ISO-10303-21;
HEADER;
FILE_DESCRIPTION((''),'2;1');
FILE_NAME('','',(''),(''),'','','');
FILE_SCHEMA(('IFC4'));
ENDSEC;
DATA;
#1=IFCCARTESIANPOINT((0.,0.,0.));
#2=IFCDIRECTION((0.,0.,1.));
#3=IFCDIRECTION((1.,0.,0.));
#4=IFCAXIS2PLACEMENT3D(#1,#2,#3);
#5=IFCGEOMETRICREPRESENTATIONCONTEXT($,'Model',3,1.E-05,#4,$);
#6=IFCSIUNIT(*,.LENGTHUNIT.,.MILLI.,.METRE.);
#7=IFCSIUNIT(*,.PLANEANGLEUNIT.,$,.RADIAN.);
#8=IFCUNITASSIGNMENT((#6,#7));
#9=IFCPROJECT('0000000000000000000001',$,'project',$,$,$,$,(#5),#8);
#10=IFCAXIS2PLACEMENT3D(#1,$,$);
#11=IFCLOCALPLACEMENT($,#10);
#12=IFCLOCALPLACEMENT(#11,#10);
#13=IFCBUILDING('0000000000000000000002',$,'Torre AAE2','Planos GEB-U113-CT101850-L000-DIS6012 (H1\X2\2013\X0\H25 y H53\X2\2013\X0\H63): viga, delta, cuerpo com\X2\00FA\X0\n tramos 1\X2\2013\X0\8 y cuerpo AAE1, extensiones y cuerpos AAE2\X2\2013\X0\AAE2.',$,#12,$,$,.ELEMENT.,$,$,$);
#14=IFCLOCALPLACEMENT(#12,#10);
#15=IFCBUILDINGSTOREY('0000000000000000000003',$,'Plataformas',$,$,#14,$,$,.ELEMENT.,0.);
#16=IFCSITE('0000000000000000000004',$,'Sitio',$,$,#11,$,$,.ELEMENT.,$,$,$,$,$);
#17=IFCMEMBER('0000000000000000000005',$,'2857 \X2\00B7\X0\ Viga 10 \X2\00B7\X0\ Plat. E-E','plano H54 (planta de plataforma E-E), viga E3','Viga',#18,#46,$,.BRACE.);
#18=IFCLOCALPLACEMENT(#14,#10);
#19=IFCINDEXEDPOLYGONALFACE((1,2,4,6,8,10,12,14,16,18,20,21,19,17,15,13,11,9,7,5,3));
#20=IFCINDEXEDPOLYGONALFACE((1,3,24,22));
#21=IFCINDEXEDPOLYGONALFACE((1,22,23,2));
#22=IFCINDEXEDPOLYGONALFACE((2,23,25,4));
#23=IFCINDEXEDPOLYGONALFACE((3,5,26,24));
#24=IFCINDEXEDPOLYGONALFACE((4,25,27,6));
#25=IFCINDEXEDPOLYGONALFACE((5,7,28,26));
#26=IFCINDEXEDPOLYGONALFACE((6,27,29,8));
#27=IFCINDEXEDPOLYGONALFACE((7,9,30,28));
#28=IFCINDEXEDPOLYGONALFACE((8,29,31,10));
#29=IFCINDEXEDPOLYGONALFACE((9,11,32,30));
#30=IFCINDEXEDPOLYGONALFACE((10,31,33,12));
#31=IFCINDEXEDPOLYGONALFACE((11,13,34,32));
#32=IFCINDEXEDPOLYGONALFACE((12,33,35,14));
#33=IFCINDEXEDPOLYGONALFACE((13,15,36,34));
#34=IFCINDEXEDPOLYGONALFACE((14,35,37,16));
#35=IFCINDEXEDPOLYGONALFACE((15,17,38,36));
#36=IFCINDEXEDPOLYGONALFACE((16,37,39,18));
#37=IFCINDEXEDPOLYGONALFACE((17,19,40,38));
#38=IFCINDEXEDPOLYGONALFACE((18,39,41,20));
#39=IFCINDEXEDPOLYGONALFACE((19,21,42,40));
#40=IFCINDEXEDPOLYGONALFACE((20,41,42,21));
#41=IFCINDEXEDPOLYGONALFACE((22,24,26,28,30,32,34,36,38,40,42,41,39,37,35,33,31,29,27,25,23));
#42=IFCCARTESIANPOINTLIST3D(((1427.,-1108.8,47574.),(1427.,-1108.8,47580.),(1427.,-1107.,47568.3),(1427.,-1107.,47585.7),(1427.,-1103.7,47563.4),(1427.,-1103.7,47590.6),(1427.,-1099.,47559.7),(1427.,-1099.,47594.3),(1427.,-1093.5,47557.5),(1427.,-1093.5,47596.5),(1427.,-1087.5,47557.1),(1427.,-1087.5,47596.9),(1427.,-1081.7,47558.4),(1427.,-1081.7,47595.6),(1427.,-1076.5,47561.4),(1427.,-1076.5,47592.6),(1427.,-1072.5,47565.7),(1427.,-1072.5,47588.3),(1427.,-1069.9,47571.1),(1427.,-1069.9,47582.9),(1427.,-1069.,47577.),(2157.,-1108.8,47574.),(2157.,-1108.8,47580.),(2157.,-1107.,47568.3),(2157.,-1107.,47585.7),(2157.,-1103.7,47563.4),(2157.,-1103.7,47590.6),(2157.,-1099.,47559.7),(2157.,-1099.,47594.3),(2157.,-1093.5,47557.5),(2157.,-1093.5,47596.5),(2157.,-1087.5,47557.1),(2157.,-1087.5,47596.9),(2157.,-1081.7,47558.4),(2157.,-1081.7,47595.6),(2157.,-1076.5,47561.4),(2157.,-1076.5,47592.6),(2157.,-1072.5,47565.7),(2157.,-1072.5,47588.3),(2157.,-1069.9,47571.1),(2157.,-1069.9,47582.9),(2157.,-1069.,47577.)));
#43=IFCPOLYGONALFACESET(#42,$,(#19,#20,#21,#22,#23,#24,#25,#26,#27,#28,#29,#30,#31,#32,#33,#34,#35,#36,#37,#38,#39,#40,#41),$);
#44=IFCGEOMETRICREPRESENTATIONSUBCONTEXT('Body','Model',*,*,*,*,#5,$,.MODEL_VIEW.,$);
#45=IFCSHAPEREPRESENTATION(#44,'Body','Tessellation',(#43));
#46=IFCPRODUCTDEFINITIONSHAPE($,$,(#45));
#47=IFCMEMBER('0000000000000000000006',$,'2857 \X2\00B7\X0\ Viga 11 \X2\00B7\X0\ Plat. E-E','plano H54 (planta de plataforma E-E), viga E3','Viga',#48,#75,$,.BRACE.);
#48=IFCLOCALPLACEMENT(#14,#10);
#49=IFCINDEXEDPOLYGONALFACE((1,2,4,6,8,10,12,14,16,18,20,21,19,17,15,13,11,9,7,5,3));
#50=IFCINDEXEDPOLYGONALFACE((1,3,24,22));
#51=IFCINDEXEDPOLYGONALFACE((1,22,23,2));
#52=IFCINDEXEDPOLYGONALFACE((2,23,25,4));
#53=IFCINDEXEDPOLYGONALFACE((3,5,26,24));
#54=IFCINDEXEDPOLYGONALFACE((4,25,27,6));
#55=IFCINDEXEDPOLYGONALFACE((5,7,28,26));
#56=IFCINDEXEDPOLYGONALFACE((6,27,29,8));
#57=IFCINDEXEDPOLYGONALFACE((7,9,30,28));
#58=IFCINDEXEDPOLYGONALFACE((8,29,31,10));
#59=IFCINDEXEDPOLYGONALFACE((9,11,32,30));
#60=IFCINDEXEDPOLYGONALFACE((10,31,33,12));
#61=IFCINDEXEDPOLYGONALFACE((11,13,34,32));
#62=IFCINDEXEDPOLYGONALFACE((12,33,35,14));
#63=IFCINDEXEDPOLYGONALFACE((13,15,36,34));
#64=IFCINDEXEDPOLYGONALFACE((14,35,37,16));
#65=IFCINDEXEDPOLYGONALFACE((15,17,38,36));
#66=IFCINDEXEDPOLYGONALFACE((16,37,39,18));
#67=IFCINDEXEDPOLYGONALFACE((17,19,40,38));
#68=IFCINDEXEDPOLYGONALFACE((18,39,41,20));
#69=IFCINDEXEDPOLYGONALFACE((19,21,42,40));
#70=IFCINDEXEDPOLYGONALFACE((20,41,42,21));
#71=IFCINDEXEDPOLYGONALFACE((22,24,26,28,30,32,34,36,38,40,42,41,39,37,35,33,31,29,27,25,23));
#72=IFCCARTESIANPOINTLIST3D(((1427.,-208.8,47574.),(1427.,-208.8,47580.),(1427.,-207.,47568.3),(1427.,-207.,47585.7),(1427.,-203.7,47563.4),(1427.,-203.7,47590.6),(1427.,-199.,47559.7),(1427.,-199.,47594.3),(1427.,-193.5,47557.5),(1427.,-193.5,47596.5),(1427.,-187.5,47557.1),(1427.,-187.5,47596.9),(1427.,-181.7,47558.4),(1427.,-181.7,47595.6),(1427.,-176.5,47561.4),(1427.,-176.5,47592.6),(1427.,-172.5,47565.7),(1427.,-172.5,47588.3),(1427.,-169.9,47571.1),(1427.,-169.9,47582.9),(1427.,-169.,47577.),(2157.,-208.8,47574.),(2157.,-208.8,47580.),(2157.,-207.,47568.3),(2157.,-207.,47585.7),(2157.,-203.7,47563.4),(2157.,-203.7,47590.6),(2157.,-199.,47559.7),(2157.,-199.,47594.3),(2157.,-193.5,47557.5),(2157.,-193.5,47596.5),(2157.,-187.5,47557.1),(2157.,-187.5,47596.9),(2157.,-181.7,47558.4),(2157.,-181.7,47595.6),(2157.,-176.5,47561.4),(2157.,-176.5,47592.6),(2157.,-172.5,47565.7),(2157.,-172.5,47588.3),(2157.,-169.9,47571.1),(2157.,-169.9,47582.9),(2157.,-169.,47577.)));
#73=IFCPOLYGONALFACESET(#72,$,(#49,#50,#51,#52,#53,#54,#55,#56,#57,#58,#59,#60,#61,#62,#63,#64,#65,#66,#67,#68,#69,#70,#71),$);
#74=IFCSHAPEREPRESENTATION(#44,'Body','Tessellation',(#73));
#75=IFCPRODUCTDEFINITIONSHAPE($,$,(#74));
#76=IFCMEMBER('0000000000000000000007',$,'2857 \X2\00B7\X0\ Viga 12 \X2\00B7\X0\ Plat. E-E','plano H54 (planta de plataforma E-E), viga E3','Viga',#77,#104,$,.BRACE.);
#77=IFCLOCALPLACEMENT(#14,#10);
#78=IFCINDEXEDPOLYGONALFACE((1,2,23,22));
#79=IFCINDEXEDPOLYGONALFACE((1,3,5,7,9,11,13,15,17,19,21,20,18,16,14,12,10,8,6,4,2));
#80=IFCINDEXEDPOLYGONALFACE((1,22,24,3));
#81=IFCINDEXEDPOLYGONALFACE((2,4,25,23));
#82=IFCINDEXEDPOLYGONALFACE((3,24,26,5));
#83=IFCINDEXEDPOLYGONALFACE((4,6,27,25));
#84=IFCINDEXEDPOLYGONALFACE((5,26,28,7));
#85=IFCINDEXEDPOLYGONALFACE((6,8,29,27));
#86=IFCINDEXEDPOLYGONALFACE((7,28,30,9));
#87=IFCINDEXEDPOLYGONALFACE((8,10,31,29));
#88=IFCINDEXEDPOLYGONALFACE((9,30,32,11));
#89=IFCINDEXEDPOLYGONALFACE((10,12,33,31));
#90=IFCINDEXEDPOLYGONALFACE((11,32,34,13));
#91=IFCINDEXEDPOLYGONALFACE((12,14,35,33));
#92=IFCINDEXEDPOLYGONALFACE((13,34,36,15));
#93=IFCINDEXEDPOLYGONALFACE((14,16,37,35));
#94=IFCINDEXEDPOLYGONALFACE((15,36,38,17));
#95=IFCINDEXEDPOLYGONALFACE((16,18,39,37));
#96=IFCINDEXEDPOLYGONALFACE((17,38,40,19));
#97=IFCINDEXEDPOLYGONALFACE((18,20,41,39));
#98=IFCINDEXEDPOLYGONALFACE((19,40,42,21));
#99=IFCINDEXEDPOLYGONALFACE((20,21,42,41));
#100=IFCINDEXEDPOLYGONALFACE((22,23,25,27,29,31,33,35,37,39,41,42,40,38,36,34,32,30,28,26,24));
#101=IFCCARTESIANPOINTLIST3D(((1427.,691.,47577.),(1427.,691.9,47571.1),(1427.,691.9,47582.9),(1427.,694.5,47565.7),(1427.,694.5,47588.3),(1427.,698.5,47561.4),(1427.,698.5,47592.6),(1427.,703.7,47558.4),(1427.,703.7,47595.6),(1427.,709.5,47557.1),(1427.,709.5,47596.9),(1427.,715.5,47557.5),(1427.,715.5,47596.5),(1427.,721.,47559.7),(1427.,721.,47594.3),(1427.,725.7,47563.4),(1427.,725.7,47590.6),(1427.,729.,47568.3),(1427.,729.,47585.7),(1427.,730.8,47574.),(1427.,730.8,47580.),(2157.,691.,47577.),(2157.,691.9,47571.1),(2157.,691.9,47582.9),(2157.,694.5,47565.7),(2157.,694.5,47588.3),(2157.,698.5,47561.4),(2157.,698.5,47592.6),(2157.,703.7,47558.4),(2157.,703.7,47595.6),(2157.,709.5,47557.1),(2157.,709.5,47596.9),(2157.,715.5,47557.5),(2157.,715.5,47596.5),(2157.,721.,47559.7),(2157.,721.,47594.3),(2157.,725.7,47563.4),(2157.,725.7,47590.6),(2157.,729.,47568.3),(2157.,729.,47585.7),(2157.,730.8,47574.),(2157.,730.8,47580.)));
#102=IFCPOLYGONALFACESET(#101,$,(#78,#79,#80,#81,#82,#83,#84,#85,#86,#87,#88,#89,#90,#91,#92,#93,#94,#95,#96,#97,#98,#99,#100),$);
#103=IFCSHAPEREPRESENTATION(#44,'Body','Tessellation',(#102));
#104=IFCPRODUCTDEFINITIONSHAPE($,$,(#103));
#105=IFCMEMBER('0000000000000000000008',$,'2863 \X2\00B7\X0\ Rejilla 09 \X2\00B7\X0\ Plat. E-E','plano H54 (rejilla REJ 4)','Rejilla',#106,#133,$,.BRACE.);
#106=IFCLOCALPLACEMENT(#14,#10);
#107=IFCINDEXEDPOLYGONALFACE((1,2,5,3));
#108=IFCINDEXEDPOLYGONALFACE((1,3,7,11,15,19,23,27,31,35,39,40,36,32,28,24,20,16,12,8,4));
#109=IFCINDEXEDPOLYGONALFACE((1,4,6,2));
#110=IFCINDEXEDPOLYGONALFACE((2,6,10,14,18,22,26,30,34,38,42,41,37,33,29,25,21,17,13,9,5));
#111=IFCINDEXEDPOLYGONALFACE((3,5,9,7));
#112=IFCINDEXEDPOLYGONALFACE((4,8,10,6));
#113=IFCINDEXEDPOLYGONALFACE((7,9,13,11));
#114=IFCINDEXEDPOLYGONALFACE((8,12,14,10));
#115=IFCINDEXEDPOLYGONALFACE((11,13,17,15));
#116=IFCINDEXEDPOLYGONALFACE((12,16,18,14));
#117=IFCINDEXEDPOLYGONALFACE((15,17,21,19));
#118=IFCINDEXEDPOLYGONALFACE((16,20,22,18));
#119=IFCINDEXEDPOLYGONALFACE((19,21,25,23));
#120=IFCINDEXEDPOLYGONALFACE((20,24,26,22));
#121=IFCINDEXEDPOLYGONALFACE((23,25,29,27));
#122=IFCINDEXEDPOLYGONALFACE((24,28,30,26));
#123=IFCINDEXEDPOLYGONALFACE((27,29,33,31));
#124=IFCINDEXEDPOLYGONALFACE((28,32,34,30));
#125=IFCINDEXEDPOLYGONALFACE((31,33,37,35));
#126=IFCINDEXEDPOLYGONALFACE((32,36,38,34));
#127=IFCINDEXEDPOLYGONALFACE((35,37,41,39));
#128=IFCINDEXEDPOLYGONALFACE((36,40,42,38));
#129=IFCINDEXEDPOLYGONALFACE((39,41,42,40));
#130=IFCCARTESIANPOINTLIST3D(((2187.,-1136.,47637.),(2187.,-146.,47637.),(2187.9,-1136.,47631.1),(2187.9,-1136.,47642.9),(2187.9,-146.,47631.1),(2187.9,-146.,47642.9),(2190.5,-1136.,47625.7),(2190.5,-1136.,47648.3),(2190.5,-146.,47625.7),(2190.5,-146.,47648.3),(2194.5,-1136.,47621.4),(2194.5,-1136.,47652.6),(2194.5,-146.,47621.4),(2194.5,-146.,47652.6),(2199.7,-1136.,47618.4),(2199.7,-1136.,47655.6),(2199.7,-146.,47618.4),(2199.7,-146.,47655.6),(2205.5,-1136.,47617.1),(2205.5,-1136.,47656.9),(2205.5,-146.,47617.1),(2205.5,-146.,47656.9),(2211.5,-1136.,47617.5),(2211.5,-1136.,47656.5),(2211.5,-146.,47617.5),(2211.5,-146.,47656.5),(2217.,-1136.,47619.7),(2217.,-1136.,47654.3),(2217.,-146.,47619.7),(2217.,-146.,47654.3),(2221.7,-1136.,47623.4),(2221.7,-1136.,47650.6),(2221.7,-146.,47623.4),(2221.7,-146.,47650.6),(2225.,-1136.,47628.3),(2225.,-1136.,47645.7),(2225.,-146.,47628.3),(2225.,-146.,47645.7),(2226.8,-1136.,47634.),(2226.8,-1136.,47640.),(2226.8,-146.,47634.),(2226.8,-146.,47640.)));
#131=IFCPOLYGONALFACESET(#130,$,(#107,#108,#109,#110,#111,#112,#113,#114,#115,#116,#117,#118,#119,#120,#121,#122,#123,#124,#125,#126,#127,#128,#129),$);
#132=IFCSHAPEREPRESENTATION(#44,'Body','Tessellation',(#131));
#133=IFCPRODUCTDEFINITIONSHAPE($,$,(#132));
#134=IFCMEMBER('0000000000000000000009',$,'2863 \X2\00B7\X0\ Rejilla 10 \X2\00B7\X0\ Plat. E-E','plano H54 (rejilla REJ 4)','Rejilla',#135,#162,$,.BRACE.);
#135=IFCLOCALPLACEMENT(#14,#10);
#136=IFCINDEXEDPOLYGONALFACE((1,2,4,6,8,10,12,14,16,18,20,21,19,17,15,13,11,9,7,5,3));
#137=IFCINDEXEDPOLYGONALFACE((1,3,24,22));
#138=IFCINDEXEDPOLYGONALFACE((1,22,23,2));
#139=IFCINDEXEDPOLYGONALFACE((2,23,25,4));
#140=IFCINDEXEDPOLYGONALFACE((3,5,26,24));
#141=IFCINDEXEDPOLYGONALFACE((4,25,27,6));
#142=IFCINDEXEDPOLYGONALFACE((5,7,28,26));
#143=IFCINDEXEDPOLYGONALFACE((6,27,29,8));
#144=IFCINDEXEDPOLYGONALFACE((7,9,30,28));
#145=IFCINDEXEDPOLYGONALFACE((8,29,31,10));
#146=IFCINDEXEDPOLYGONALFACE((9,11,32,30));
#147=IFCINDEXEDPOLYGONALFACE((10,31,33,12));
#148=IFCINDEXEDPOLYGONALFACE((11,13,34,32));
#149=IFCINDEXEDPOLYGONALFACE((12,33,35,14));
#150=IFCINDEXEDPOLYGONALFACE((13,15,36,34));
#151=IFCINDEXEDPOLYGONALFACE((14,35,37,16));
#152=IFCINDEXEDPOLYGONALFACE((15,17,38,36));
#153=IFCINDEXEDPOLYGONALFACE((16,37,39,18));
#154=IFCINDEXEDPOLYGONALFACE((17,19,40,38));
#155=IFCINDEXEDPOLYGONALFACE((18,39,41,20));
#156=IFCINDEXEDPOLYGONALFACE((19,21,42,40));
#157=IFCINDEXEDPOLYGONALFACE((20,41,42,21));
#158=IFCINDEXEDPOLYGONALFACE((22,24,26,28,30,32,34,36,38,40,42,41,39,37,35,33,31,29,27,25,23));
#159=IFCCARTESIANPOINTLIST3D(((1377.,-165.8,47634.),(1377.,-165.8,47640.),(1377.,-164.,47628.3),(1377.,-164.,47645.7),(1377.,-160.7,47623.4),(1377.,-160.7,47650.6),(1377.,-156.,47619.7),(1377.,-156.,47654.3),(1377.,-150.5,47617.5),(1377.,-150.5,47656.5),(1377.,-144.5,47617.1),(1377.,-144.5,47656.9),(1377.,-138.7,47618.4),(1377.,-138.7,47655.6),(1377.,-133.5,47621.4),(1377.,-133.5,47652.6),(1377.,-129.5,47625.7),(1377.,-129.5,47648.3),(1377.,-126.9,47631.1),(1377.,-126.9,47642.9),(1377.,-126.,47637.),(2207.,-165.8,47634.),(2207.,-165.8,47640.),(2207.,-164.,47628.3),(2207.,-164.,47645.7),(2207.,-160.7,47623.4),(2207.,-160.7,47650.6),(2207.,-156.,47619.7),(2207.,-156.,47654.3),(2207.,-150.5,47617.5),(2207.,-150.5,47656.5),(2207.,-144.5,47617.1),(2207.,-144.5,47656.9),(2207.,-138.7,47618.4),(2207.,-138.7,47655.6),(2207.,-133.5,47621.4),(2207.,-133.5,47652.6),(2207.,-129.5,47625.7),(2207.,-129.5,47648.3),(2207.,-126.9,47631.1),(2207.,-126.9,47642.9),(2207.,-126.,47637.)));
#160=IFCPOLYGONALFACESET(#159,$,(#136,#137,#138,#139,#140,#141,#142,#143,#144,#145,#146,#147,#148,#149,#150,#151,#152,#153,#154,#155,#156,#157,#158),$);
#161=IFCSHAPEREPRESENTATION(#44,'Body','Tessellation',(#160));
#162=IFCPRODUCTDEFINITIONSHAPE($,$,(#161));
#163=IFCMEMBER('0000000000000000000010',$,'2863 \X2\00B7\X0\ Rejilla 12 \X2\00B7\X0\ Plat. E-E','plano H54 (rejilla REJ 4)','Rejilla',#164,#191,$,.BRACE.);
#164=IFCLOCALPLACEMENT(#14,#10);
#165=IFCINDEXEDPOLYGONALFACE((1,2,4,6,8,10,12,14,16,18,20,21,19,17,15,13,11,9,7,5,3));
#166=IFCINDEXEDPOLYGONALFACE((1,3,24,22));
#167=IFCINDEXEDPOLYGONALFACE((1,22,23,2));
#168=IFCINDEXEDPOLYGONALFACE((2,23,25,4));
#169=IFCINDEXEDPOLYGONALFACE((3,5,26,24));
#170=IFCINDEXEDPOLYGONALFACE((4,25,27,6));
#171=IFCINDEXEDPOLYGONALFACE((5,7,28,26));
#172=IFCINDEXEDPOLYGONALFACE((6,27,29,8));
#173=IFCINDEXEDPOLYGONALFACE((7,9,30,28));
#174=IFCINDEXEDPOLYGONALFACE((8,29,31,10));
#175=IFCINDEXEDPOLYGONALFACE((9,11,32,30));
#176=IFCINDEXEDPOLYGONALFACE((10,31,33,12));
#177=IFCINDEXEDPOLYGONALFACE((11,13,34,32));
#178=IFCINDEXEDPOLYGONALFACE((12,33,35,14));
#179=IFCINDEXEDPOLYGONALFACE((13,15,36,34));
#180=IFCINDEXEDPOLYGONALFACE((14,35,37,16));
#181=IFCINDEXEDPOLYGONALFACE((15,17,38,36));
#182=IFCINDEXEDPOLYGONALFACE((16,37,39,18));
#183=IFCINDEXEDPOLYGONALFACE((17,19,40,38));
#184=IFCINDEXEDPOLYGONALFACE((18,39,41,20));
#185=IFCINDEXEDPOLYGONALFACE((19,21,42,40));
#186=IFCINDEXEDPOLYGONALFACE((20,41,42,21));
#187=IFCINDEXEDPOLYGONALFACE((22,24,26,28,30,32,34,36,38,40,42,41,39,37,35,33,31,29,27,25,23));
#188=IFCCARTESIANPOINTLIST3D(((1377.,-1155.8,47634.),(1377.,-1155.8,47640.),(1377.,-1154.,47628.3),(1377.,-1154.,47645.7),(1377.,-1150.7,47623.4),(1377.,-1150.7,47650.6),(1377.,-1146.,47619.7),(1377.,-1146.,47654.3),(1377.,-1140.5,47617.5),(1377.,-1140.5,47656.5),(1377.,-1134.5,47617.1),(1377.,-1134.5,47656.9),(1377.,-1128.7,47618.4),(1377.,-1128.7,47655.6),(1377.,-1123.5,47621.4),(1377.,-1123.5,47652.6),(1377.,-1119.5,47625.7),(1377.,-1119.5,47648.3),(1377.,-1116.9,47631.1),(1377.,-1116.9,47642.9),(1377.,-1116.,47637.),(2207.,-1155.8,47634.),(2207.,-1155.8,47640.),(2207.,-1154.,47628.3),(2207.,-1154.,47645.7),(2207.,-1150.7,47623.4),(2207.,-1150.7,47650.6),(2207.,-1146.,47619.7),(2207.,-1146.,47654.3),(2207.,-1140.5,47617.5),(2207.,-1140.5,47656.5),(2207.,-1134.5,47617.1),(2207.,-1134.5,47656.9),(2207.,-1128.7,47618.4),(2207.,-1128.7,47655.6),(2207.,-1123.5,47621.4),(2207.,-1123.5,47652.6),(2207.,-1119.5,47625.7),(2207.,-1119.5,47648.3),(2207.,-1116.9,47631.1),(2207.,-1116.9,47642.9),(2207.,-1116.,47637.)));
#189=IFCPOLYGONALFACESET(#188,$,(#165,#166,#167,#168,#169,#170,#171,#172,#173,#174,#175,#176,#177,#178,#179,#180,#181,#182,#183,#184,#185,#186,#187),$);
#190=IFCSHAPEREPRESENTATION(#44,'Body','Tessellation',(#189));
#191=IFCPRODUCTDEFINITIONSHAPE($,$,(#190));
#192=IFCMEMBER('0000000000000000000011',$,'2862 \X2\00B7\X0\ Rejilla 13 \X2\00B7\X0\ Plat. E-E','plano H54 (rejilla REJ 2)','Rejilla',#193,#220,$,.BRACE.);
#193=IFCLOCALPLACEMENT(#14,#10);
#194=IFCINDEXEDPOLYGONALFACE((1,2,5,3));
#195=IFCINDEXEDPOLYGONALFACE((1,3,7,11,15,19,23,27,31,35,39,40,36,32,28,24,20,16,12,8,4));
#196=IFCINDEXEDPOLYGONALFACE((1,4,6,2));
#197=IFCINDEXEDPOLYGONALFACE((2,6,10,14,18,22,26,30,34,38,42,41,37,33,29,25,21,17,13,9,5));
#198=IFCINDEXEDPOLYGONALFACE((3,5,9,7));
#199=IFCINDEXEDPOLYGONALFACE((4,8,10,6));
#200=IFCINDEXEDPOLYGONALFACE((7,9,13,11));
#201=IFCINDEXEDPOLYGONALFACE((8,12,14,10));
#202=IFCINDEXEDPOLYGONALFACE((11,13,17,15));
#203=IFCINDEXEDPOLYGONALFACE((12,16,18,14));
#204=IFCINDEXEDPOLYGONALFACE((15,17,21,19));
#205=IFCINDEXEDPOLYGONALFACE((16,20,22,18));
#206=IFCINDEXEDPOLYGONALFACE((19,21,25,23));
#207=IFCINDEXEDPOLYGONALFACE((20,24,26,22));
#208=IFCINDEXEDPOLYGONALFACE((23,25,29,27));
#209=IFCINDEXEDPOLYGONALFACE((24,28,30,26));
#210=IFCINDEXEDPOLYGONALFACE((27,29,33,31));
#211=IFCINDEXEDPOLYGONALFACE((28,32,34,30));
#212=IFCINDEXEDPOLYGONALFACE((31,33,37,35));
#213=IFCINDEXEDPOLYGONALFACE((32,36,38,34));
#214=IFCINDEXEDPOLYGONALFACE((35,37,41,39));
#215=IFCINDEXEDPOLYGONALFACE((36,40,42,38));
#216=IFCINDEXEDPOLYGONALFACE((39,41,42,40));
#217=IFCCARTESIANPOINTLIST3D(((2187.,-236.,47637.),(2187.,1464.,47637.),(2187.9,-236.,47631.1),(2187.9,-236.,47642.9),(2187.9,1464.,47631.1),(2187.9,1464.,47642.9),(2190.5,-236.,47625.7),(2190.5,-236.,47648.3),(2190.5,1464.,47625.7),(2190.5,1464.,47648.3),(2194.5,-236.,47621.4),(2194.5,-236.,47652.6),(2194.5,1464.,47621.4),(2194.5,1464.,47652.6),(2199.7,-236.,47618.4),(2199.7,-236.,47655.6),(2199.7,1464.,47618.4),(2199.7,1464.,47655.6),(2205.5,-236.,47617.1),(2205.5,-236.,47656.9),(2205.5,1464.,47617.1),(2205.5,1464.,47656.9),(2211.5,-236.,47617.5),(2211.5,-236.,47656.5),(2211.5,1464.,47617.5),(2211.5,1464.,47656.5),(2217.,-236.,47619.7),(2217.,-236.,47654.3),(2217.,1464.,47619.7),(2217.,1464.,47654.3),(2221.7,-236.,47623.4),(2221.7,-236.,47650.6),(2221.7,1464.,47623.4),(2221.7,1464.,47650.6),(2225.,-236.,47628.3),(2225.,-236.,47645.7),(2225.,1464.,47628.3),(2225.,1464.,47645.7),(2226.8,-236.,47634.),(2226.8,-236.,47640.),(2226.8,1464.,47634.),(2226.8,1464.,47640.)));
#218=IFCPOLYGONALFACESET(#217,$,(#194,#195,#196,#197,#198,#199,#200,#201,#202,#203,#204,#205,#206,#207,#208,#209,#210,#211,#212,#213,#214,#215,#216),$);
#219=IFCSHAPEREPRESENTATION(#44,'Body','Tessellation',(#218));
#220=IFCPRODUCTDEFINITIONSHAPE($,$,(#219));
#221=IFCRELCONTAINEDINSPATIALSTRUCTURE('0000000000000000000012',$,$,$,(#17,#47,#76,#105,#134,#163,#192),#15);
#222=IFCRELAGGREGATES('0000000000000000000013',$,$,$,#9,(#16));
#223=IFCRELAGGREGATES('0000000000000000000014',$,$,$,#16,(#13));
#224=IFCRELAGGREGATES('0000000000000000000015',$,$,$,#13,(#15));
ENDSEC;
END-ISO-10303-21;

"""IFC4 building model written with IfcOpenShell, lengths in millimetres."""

from ifc_helpers import new_model, si_unit, frame, origin, origin_with_axes, place, context, subcontext, project, spatial, circle, extrude, element, save


model = new_model("IFC4")

# Units and contexts
model_context = context("Model", 3, precision=1e-05, world=origin_with_axes())
body_context = subcontext(model_context, "Body", "Model", "MODEL_VIEW")
ifc_project = project(units=[si_unit("LENGTHUNIT", "METRE", prefix="MILLI"), si_unit("PLANEANGLEUNIT", "RADIAN")], contexts=[model_context])

# Site, building, storey
site_placement = place(None, origin())
site = spatial("IfcSite", under=ifc_project, at=site_placement, Name="Sitio", CompositionType="ELEMENT")
building_placement = place(site_placement, origin())
building = spatial("IfcBuilding", under=site, at=building_placement, Name="Torre AAE2", Description="Planos GEB-U113-CT101850-L000-DIS6012 (H1–H25 y H53–H63): viga, delta, cuerpo común tramos 1–8 y cuerpo AAE1, extensiones y cuerpos AAE2–AAE2.", CompositionType="ELEMENT")
storey_placement = place(building_placement, origin())
storey = spatial("IfcBuildingStorey", under=building, at=storey_placement, Name="Plataformas", CompositionType="ELEMENT", Elevation=0.0)

# Members
for number, where, z_axis, x_axis, name in (
    (1, (2157.0, -1089.0, 47577.0), (-1.0, 0.0, 0.0), (0.0, 1.0, 0.0), "2857 · Viga 10 · Plat. E-E"),
    (2, (2157.0, -189.0, 47577.0), (-1.0, 0.0, 0.0), (0.0, 1.0, 0.0), "2857 · Viga 11 · Plat. E-E"),
    (3, (2157.0, 711.0, 47577.0), (-1.0, 0.0, 0.0), (0.0, -1.0, 0.0), "2857 · Viga 12 · Plat. E-E"),
):
    element("IfcMember", number, at=place(storey_placement, frame(where, z_axis=z_axis, x_axis=x_axis)), inside=storey, Name=name, Description="plano H54 (planta de plataforma E-E), viga E3", ObjectType="Viga", PredefinedType="BRACE", context=body_context, shape_type="SweptSolid", body=[
        extrude(circle(Radius=20.0), None, (0.0, 0.0, 1.0), 730.0),
    ])
member_1_placement = place(storey_placement, frame((2207.0, -1136.0, 47637.0), z_axis=(0.0, 1.0, 0.0), x_axis=(-1.0, 0.0, 0.0)))
element("IfcMember", 4, at=member_1_placement, inside=storey, Name="2863 · Rejilla 09 · Plat. E-E", Description="plano H54 (rejilla REJ 4)", ObjectType="Rejilla", PredefinedType="BRACE", context=body_context, shape_type="SweptSolid", body=[
    extrude(circle(Radius=20.0), None, (0.0, 0.0, 1.0), 990.0),
])
for number, where, z_axis, x_axis, name in (
    (5, (2207.0, -146.0, 47637.0), (-1.0, 0.0, 0.0), (0.0, 1.0, 0.0), "2863 · Rejilla 10 · Plat. E-E"),
    (6, (1377.0, -1136.0, 47637.0), (1.0, 0.0, 0.0), (0.0, 1.0, 0.0), "2863 · Rejilla 12 · Plat. E-E"),
):
    element("IfcMember", number, at=place(storey_placement, frame(where, z_axis=z_axis, x_axis=x_axis)), inside=storey, Name=name, Description="plano H54 (rejilla REJ 4)", ObjectType="Rejilla", PredefinedType="BRACE", context=body_context, shape_type="SweptSolid", body=[
        extrude(circle(Radius=20.0), None, (0.0, 0.0, 1.0), 830.0),
    ])
member_2_placement = place(storey_placement, frame((2207.0, -236.0, 47637.0), z_axis=(0.0, 1.0, 0.0), x_axis=(-1.0, 0.0, 0.0)))
element("IfcMember", 7, at=member_2_placement, inside=storey, Name="2862 · Rejilla 13 · Plat. E-E", Description="plano H54 (rejilla REJ 2)", ObjectType="Rejilla", PredefinedType="BRACE", context=body_context, shape_type="SweptSolid", body=[
    extrude(circle(Radius=20.0), None, (0.0, 0.0, 1.0), 1700.0),
])

save(model, "model.ifc")
